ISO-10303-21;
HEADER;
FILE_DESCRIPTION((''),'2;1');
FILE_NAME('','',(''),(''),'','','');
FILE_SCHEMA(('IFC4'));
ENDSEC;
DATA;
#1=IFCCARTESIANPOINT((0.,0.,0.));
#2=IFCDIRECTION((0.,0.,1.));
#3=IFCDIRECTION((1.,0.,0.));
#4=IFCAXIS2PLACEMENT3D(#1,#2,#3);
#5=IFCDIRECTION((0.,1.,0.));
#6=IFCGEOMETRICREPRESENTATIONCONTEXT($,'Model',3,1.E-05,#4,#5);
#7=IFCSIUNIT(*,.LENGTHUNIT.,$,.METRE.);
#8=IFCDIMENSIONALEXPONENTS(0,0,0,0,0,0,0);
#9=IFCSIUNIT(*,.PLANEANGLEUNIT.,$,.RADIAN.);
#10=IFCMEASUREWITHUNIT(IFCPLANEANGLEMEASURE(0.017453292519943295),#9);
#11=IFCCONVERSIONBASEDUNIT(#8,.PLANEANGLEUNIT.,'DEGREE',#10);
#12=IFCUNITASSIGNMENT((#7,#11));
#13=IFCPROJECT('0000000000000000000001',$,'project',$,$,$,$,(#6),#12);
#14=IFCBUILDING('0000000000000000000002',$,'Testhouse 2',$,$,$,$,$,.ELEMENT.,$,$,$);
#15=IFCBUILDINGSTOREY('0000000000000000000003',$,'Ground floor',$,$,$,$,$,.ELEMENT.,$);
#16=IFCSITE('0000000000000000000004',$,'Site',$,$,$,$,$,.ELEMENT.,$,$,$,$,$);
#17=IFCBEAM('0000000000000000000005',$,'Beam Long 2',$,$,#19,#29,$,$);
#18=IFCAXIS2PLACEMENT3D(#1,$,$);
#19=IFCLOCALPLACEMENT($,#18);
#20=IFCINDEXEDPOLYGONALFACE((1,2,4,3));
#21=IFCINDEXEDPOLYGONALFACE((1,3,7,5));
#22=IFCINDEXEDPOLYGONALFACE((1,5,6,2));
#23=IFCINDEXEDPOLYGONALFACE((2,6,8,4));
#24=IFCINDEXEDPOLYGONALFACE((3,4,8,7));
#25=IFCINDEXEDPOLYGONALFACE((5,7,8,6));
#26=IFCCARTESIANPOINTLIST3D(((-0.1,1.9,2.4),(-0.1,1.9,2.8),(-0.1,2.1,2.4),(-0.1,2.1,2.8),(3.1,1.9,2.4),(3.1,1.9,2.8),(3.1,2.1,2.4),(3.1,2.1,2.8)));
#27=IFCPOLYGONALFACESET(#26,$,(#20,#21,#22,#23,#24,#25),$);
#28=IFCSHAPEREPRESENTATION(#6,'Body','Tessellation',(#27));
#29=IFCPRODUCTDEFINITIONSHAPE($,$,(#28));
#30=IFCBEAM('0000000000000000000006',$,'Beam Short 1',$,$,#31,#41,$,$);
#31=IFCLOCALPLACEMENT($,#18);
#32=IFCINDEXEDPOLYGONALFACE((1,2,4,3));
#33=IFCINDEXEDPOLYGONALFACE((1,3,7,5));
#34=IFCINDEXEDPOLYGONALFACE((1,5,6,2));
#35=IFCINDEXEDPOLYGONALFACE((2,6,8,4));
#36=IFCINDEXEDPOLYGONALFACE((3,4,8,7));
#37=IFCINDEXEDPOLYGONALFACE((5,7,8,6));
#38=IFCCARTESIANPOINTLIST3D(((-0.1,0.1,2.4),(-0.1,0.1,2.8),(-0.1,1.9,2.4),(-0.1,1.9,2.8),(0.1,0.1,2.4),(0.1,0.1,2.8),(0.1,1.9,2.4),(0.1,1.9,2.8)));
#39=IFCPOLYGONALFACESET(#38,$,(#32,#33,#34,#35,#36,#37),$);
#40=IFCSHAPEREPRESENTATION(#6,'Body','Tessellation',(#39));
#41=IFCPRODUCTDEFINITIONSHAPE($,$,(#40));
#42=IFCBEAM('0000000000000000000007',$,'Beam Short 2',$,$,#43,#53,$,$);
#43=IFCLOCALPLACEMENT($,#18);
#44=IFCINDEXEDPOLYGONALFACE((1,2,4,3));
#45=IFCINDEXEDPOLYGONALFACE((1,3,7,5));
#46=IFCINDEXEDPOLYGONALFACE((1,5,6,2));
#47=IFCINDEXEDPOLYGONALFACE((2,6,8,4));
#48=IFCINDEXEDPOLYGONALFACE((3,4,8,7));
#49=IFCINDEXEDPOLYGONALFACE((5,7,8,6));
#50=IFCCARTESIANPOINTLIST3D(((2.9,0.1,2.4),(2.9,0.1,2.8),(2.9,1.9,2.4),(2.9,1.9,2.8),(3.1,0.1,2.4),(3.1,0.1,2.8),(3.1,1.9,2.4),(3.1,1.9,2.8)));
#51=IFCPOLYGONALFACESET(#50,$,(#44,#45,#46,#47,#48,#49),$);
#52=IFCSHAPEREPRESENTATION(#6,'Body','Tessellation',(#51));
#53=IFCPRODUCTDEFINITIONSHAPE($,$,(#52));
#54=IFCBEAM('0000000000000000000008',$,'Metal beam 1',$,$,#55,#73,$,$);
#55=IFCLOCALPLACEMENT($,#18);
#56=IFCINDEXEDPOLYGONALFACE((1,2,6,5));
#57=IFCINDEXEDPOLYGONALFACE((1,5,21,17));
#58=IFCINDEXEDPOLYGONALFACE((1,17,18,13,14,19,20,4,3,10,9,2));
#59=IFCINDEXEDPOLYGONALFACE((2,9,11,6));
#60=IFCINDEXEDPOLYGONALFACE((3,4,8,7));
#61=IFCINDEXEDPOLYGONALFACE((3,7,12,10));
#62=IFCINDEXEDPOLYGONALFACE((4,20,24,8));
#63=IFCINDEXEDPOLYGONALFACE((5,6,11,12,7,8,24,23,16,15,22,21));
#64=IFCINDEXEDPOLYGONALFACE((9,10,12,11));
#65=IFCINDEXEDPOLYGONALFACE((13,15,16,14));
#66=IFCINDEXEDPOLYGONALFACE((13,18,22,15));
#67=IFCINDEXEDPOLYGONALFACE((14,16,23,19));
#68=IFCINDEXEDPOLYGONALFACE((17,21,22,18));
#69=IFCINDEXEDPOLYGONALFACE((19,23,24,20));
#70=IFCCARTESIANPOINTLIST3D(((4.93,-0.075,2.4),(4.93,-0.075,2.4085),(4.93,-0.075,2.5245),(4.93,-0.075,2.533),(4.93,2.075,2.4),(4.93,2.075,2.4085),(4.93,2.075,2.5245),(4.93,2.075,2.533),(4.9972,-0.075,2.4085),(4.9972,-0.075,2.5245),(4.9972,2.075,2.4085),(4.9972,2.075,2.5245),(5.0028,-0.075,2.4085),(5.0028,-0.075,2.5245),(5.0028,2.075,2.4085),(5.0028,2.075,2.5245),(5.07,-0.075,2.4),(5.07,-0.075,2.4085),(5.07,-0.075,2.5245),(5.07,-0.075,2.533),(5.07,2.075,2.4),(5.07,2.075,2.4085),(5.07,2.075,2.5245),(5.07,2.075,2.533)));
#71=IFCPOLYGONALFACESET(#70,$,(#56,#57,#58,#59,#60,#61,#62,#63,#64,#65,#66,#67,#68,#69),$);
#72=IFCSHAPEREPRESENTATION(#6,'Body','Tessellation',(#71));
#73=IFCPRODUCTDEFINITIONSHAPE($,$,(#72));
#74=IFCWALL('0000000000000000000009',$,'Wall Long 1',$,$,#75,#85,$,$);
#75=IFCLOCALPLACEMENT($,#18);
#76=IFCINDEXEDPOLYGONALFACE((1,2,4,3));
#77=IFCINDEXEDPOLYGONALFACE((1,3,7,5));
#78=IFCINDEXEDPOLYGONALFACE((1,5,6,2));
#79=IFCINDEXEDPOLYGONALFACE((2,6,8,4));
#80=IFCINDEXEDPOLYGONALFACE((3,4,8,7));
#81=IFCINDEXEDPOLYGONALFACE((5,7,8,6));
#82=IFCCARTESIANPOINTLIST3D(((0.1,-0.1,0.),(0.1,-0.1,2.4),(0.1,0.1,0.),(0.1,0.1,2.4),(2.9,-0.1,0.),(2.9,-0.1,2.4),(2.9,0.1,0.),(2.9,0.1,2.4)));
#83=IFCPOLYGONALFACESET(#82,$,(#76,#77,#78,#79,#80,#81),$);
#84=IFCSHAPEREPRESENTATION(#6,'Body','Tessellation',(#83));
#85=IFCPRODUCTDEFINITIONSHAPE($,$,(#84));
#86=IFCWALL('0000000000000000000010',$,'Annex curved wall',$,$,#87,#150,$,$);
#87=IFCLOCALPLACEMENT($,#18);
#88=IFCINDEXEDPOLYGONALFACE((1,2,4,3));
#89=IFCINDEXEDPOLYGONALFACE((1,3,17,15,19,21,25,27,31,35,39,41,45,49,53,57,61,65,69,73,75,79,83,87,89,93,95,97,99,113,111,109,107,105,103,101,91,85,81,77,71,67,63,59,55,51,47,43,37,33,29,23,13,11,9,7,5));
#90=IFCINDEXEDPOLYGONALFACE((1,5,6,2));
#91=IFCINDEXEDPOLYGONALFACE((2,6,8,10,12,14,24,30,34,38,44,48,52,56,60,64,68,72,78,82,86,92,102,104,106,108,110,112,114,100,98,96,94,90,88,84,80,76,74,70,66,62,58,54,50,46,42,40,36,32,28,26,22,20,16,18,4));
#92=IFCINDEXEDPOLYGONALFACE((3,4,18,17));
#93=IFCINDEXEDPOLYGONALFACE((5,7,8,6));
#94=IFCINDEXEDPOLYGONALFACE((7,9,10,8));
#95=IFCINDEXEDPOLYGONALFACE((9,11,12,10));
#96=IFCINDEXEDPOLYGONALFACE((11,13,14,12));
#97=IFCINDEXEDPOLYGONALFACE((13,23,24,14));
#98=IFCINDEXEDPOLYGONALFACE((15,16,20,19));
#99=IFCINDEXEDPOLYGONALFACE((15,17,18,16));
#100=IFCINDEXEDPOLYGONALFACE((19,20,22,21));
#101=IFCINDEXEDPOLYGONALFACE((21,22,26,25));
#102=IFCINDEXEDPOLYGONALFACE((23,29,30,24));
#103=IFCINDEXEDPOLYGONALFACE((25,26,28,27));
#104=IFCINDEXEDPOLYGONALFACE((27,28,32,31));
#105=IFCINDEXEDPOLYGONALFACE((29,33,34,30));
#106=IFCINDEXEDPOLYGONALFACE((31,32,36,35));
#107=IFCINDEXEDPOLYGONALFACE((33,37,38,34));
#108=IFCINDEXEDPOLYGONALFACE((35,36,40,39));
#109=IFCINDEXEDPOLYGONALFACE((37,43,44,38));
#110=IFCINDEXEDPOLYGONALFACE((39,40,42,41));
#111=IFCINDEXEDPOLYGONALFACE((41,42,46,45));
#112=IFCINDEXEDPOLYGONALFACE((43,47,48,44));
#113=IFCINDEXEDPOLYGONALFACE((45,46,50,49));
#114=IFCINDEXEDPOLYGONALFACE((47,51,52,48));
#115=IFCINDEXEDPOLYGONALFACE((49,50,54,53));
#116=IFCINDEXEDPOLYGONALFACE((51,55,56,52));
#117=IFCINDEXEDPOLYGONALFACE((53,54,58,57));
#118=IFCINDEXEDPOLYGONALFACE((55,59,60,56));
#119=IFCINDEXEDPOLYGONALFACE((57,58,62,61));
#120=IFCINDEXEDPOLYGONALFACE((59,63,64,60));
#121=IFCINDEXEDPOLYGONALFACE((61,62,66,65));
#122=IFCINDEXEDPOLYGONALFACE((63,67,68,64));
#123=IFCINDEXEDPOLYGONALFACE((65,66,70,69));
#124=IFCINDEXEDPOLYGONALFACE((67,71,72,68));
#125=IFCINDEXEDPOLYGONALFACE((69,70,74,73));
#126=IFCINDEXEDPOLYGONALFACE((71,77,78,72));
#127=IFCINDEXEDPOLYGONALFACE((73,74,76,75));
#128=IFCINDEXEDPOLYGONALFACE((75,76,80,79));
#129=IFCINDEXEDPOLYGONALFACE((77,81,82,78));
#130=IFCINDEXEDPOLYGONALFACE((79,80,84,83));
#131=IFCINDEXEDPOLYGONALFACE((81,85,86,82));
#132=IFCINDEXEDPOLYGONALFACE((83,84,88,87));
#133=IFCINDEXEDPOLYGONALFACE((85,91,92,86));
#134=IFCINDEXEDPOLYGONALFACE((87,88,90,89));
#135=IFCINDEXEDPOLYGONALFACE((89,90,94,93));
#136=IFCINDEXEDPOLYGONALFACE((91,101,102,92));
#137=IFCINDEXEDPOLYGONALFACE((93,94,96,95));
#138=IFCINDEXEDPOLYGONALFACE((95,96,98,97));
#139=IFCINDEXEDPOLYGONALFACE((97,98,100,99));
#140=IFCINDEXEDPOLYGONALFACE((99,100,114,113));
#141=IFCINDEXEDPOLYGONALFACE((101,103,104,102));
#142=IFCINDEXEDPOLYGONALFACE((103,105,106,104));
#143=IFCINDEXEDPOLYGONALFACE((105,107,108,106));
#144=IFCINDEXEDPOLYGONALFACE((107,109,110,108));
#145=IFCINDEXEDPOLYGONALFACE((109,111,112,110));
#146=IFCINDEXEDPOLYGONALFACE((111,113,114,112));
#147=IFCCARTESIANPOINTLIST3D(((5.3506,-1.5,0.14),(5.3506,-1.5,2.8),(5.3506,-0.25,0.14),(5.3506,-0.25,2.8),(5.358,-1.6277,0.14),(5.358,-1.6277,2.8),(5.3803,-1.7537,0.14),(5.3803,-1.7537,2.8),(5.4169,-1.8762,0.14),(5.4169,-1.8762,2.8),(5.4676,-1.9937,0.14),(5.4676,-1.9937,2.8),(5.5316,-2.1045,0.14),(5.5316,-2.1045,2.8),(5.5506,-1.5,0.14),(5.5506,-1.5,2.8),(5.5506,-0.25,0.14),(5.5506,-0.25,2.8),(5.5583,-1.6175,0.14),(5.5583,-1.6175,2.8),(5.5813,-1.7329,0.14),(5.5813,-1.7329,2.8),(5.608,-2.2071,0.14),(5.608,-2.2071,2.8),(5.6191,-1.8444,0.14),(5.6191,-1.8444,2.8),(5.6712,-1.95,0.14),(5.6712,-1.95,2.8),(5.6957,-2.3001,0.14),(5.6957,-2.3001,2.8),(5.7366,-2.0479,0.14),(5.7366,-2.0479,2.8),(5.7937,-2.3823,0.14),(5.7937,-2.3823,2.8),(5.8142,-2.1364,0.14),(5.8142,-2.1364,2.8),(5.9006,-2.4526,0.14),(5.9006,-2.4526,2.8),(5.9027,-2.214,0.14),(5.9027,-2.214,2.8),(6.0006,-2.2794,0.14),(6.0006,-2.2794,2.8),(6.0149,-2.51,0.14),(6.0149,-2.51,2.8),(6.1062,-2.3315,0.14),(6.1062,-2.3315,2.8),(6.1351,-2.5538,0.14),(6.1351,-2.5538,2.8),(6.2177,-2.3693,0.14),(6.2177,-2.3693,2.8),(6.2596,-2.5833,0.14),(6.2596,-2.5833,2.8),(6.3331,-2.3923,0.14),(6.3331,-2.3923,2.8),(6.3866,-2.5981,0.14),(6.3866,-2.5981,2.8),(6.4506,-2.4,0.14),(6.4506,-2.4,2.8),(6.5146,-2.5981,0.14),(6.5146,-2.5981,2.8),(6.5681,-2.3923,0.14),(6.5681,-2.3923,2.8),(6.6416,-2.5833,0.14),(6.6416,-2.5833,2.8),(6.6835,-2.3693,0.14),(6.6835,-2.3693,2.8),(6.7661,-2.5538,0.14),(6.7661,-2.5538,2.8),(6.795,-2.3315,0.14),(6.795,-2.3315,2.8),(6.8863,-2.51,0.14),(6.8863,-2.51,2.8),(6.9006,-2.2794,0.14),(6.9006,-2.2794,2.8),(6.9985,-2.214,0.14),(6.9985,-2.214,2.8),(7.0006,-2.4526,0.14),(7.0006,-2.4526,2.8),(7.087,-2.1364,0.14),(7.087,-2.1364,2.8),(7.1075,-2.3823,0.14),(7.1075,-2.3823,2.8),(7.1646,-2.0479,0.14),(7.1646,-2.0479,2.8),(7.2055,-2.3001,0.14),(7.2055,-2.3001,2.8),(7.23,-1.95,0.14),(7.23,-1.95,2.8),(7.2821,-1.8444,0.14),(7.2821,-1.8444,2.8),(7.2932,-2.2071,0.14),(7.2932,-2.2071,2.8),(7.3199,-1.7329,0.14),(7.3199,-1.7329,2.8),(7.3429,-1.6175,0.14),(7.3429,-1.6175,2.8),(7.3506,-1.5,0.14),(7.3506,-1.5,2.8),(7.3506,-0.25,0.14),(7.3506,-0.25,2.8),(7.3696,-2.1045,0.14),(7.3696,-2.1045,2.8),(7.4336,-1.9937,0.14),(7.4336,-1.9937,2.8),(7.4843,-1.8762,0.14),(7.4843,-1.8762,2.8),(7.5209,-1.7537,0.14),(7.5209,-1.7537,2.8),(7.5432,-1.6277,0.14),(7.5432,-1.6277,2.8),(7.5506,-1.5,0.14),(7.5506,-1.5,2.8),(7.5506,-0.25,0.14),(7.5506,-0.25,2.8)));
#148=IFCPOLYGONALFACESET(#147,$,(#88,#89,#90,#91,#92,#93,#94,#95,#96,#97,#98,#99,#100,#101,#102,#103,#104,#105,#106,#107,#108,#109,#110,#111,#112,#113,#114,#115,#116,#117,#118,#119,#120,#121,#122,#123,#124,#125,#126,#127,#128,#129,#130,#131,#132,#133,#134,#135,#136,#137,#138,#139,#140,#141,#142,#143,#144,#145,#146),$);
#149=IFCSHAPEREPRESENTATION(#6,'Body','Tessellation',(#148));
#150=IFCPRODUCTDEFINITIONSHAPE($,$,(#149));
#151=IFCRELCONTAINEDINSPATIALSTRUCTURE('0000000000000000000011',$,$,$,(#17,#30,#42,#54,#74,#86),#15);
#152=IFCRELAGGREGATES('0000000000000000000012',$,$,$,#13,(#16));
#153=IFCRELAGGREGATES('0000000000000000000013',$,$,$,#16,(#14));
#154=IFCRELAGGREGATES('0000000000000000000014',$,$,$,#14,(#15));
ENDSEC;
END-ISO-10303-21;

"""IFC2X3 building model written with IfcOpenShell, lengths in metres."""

from ifc_helpers import new_model, entity, si_unit, converted_unit, direction, frame, frame_2d, origin_with_axes, place, context, project, spatial, polyline, circle_curve, parameter, trimmed, segment, composite_curve, outline, extrude, element, save


model = new_model("IFC2X3")

# Units and contexts
model_context = context("Model", 3, precision=1e-05, world=origin_with_axes(), true_north=direction((0.0, 1.0, 0.0)))
ifc_project = project(units=[si_unit("LENGTHUNIT", "METRE"), converted_unit("PLANEANGLEUNIT", "DEGREE", entity("IfcPlaneAngleMeasure", 0.017453292519943295), si_unit("PLANEANGLEUNIT", "RADIAN"), dimensions=[0, 0, 0, 0, 0, 0, 0])], contexts=[model_context])

# Site, building, storey
site = spatial("IfcSite", under=ifc_project, Name="Site", CompositionType="ELEMENT")
building = spatial("IfcBuilding", under=site, Name="Testhouse 2", CompositionType="ELEMENT")
storey = spatial("IfcBuildingStorey", under=building, Name="Ground floor", CompositionType="ELEMENT")

# Beams
beam_1_placement = place(None, origin_with_axes())
element("IfcBeam", 1, at=beam_1_placement, inside=storey, Name="Beam Long 2", context=model_context, shape_type="SweptSolid", body=[
    extrude(outline(polyline([(-0.2, -0.1), (0.2, -0.1), (0.2, 0.1), (-0.2, 0.1), (-0.2, -0.1)])), frame((-0.1, 2.0, 2.6), z_axis=(1.0, 0.0, 0.0), x_axis=(0.0, 0.0, -1.0)), (0.0, 0.0, 1.0), 3.2),
])
beam_2_placement = place(None, origin_with_axes())
element("IfcBeam", 2, at=beam_2_placement, inside=storey, Name="Beam Short 1", context=model_context, shape_type="SweptSolid", body=[
    extrude(outline(polyline([(-0.2, -0.1), (0.2, -0.1), (0.2, 0.1), (-0.2, 0.1), (-0.2, -0.1)])), frame((0.0, 0.1, 2.6), z_axis=(0.0, 1.0, 0.0), x_axis=(0.0, 0.0, -1.0)), (0.0, 0.0, 1.0), 1.8),
])
beam_3_placement = place(None, origin_with_axes())
element("IfcBeam", 3, at=beam_3_placement, inside=storey, Name="Beam Short 2", context=model_context, shape_type="SweptSolid", body=[
    extrude(outline(polyline([(-0.2, -0.1), (0.2, -0.1), (0.2, 0.1), (-0.2, 0.1), (-0.2, -0.1)])), frame((3.0, 0.1, 2.6), z_axis=(0.0, 1.0, 0.0), x_axis=(0.0, 0.0, -1.0)), (0.0, 0.0, 1.0), 1.8),
])
beam_4_placement = place(None, origin_with_axes())
element("IfcBeam", 4, at=beam_4_placement, inside=storey, Name="Metal beam 1", context=model_context, shape_type="SweptSolid", body=[
    extrude(outline(polyline([(-0.07, -0.0665), (0.07, -0.0665), (0.07, -0.058), (0.0027, -0.058), (0.0027, 0.058), (0.07, 0.058), (0.07, 0.0665), (-0.07, 0.0665), (-0.07, 0.058), (-0.0027, 0.058), (-0.0027, -0.058), (-0.07, -0.058), (-0.07, -0.0665)])), frame((5.0, 2.075, 2.4665), z_axis=(0.0, -1.0, 0.0), x_axis=(1.0, 0.0, 0.0)), (0.0, 0.0, 1.0), 2.15),
])

# Walls
wall_1_placement = place(None, origin_with_axes())
element("IfcWall", 5, at=wall_1_placement, inside=storey, Name="Wall Long 1", context=model_context, shape_type="SweptSolid", body=[
    extrude(outline(polyline([(0.1, -0.1), (0.1, 0.1), (2.9, 0.1), (2.9, -0.1), (0.1, -0.1)])), origin_with_axes(), (0.0, 0.0, 1.0), 2.4),
])
wall_2_placement = place(None, origin_with_axes())
element("IfcWall", 6, at=wall_2_placement, inside=storey, Name="Annex curved wall", context=model_context, shape_type="SweptSolid", body=[
    extrude(outline(composite_curve([segment(polyline([(5.3506, -0.25), (5.5506, -0.25)]), True, "CONTINUOUS"), segment(polyline([(5.5506, -0.25), (5.5506, -1.5)]), True, "CONTINUOUS"), segment(trimmed(circle_curve(frame_2d((6.4506, -1.5), x_axis=(1.0, 0.0)), 0.9), [parameter(180.0)], [parameter(0.0)], True, "PARAMETER"), True, "CONTINUOUS"), segment(polyline([(7.3506, -1.5), (7.3506, -0.25)]), True, "CONTINUOUS"), segment(polyline([(7.3506, -0.25), (7.5506, -0.25)]), True, "CONTINUOUS"), segment(polyline([(7.5506, -0.25), (7.5506, -1.5)]), True, "CONTINUOUS"), segment(trimmed(circle_curve(frame_2d((6.4506, -1.5), x_axis=(1.0, 0.0)), 1.1), [parameter(0.0)], [parameter(180.0)], False, "PARAMETER"), True, "CONTINUOUS"), segment(polyline([(5.3506, -1.5), (5.3506, -0.25)]), True, "CONTINUOUS")], self_intersect=False)), frame((0.0, 0.0, 0.14), z_axis=(0.0, 0.0, 1.0), x_axis=(1.0, 0.0, 0.0)), (0.0, 0.0, 1.0), 2.66),
])

save(model, "model.ifc")
